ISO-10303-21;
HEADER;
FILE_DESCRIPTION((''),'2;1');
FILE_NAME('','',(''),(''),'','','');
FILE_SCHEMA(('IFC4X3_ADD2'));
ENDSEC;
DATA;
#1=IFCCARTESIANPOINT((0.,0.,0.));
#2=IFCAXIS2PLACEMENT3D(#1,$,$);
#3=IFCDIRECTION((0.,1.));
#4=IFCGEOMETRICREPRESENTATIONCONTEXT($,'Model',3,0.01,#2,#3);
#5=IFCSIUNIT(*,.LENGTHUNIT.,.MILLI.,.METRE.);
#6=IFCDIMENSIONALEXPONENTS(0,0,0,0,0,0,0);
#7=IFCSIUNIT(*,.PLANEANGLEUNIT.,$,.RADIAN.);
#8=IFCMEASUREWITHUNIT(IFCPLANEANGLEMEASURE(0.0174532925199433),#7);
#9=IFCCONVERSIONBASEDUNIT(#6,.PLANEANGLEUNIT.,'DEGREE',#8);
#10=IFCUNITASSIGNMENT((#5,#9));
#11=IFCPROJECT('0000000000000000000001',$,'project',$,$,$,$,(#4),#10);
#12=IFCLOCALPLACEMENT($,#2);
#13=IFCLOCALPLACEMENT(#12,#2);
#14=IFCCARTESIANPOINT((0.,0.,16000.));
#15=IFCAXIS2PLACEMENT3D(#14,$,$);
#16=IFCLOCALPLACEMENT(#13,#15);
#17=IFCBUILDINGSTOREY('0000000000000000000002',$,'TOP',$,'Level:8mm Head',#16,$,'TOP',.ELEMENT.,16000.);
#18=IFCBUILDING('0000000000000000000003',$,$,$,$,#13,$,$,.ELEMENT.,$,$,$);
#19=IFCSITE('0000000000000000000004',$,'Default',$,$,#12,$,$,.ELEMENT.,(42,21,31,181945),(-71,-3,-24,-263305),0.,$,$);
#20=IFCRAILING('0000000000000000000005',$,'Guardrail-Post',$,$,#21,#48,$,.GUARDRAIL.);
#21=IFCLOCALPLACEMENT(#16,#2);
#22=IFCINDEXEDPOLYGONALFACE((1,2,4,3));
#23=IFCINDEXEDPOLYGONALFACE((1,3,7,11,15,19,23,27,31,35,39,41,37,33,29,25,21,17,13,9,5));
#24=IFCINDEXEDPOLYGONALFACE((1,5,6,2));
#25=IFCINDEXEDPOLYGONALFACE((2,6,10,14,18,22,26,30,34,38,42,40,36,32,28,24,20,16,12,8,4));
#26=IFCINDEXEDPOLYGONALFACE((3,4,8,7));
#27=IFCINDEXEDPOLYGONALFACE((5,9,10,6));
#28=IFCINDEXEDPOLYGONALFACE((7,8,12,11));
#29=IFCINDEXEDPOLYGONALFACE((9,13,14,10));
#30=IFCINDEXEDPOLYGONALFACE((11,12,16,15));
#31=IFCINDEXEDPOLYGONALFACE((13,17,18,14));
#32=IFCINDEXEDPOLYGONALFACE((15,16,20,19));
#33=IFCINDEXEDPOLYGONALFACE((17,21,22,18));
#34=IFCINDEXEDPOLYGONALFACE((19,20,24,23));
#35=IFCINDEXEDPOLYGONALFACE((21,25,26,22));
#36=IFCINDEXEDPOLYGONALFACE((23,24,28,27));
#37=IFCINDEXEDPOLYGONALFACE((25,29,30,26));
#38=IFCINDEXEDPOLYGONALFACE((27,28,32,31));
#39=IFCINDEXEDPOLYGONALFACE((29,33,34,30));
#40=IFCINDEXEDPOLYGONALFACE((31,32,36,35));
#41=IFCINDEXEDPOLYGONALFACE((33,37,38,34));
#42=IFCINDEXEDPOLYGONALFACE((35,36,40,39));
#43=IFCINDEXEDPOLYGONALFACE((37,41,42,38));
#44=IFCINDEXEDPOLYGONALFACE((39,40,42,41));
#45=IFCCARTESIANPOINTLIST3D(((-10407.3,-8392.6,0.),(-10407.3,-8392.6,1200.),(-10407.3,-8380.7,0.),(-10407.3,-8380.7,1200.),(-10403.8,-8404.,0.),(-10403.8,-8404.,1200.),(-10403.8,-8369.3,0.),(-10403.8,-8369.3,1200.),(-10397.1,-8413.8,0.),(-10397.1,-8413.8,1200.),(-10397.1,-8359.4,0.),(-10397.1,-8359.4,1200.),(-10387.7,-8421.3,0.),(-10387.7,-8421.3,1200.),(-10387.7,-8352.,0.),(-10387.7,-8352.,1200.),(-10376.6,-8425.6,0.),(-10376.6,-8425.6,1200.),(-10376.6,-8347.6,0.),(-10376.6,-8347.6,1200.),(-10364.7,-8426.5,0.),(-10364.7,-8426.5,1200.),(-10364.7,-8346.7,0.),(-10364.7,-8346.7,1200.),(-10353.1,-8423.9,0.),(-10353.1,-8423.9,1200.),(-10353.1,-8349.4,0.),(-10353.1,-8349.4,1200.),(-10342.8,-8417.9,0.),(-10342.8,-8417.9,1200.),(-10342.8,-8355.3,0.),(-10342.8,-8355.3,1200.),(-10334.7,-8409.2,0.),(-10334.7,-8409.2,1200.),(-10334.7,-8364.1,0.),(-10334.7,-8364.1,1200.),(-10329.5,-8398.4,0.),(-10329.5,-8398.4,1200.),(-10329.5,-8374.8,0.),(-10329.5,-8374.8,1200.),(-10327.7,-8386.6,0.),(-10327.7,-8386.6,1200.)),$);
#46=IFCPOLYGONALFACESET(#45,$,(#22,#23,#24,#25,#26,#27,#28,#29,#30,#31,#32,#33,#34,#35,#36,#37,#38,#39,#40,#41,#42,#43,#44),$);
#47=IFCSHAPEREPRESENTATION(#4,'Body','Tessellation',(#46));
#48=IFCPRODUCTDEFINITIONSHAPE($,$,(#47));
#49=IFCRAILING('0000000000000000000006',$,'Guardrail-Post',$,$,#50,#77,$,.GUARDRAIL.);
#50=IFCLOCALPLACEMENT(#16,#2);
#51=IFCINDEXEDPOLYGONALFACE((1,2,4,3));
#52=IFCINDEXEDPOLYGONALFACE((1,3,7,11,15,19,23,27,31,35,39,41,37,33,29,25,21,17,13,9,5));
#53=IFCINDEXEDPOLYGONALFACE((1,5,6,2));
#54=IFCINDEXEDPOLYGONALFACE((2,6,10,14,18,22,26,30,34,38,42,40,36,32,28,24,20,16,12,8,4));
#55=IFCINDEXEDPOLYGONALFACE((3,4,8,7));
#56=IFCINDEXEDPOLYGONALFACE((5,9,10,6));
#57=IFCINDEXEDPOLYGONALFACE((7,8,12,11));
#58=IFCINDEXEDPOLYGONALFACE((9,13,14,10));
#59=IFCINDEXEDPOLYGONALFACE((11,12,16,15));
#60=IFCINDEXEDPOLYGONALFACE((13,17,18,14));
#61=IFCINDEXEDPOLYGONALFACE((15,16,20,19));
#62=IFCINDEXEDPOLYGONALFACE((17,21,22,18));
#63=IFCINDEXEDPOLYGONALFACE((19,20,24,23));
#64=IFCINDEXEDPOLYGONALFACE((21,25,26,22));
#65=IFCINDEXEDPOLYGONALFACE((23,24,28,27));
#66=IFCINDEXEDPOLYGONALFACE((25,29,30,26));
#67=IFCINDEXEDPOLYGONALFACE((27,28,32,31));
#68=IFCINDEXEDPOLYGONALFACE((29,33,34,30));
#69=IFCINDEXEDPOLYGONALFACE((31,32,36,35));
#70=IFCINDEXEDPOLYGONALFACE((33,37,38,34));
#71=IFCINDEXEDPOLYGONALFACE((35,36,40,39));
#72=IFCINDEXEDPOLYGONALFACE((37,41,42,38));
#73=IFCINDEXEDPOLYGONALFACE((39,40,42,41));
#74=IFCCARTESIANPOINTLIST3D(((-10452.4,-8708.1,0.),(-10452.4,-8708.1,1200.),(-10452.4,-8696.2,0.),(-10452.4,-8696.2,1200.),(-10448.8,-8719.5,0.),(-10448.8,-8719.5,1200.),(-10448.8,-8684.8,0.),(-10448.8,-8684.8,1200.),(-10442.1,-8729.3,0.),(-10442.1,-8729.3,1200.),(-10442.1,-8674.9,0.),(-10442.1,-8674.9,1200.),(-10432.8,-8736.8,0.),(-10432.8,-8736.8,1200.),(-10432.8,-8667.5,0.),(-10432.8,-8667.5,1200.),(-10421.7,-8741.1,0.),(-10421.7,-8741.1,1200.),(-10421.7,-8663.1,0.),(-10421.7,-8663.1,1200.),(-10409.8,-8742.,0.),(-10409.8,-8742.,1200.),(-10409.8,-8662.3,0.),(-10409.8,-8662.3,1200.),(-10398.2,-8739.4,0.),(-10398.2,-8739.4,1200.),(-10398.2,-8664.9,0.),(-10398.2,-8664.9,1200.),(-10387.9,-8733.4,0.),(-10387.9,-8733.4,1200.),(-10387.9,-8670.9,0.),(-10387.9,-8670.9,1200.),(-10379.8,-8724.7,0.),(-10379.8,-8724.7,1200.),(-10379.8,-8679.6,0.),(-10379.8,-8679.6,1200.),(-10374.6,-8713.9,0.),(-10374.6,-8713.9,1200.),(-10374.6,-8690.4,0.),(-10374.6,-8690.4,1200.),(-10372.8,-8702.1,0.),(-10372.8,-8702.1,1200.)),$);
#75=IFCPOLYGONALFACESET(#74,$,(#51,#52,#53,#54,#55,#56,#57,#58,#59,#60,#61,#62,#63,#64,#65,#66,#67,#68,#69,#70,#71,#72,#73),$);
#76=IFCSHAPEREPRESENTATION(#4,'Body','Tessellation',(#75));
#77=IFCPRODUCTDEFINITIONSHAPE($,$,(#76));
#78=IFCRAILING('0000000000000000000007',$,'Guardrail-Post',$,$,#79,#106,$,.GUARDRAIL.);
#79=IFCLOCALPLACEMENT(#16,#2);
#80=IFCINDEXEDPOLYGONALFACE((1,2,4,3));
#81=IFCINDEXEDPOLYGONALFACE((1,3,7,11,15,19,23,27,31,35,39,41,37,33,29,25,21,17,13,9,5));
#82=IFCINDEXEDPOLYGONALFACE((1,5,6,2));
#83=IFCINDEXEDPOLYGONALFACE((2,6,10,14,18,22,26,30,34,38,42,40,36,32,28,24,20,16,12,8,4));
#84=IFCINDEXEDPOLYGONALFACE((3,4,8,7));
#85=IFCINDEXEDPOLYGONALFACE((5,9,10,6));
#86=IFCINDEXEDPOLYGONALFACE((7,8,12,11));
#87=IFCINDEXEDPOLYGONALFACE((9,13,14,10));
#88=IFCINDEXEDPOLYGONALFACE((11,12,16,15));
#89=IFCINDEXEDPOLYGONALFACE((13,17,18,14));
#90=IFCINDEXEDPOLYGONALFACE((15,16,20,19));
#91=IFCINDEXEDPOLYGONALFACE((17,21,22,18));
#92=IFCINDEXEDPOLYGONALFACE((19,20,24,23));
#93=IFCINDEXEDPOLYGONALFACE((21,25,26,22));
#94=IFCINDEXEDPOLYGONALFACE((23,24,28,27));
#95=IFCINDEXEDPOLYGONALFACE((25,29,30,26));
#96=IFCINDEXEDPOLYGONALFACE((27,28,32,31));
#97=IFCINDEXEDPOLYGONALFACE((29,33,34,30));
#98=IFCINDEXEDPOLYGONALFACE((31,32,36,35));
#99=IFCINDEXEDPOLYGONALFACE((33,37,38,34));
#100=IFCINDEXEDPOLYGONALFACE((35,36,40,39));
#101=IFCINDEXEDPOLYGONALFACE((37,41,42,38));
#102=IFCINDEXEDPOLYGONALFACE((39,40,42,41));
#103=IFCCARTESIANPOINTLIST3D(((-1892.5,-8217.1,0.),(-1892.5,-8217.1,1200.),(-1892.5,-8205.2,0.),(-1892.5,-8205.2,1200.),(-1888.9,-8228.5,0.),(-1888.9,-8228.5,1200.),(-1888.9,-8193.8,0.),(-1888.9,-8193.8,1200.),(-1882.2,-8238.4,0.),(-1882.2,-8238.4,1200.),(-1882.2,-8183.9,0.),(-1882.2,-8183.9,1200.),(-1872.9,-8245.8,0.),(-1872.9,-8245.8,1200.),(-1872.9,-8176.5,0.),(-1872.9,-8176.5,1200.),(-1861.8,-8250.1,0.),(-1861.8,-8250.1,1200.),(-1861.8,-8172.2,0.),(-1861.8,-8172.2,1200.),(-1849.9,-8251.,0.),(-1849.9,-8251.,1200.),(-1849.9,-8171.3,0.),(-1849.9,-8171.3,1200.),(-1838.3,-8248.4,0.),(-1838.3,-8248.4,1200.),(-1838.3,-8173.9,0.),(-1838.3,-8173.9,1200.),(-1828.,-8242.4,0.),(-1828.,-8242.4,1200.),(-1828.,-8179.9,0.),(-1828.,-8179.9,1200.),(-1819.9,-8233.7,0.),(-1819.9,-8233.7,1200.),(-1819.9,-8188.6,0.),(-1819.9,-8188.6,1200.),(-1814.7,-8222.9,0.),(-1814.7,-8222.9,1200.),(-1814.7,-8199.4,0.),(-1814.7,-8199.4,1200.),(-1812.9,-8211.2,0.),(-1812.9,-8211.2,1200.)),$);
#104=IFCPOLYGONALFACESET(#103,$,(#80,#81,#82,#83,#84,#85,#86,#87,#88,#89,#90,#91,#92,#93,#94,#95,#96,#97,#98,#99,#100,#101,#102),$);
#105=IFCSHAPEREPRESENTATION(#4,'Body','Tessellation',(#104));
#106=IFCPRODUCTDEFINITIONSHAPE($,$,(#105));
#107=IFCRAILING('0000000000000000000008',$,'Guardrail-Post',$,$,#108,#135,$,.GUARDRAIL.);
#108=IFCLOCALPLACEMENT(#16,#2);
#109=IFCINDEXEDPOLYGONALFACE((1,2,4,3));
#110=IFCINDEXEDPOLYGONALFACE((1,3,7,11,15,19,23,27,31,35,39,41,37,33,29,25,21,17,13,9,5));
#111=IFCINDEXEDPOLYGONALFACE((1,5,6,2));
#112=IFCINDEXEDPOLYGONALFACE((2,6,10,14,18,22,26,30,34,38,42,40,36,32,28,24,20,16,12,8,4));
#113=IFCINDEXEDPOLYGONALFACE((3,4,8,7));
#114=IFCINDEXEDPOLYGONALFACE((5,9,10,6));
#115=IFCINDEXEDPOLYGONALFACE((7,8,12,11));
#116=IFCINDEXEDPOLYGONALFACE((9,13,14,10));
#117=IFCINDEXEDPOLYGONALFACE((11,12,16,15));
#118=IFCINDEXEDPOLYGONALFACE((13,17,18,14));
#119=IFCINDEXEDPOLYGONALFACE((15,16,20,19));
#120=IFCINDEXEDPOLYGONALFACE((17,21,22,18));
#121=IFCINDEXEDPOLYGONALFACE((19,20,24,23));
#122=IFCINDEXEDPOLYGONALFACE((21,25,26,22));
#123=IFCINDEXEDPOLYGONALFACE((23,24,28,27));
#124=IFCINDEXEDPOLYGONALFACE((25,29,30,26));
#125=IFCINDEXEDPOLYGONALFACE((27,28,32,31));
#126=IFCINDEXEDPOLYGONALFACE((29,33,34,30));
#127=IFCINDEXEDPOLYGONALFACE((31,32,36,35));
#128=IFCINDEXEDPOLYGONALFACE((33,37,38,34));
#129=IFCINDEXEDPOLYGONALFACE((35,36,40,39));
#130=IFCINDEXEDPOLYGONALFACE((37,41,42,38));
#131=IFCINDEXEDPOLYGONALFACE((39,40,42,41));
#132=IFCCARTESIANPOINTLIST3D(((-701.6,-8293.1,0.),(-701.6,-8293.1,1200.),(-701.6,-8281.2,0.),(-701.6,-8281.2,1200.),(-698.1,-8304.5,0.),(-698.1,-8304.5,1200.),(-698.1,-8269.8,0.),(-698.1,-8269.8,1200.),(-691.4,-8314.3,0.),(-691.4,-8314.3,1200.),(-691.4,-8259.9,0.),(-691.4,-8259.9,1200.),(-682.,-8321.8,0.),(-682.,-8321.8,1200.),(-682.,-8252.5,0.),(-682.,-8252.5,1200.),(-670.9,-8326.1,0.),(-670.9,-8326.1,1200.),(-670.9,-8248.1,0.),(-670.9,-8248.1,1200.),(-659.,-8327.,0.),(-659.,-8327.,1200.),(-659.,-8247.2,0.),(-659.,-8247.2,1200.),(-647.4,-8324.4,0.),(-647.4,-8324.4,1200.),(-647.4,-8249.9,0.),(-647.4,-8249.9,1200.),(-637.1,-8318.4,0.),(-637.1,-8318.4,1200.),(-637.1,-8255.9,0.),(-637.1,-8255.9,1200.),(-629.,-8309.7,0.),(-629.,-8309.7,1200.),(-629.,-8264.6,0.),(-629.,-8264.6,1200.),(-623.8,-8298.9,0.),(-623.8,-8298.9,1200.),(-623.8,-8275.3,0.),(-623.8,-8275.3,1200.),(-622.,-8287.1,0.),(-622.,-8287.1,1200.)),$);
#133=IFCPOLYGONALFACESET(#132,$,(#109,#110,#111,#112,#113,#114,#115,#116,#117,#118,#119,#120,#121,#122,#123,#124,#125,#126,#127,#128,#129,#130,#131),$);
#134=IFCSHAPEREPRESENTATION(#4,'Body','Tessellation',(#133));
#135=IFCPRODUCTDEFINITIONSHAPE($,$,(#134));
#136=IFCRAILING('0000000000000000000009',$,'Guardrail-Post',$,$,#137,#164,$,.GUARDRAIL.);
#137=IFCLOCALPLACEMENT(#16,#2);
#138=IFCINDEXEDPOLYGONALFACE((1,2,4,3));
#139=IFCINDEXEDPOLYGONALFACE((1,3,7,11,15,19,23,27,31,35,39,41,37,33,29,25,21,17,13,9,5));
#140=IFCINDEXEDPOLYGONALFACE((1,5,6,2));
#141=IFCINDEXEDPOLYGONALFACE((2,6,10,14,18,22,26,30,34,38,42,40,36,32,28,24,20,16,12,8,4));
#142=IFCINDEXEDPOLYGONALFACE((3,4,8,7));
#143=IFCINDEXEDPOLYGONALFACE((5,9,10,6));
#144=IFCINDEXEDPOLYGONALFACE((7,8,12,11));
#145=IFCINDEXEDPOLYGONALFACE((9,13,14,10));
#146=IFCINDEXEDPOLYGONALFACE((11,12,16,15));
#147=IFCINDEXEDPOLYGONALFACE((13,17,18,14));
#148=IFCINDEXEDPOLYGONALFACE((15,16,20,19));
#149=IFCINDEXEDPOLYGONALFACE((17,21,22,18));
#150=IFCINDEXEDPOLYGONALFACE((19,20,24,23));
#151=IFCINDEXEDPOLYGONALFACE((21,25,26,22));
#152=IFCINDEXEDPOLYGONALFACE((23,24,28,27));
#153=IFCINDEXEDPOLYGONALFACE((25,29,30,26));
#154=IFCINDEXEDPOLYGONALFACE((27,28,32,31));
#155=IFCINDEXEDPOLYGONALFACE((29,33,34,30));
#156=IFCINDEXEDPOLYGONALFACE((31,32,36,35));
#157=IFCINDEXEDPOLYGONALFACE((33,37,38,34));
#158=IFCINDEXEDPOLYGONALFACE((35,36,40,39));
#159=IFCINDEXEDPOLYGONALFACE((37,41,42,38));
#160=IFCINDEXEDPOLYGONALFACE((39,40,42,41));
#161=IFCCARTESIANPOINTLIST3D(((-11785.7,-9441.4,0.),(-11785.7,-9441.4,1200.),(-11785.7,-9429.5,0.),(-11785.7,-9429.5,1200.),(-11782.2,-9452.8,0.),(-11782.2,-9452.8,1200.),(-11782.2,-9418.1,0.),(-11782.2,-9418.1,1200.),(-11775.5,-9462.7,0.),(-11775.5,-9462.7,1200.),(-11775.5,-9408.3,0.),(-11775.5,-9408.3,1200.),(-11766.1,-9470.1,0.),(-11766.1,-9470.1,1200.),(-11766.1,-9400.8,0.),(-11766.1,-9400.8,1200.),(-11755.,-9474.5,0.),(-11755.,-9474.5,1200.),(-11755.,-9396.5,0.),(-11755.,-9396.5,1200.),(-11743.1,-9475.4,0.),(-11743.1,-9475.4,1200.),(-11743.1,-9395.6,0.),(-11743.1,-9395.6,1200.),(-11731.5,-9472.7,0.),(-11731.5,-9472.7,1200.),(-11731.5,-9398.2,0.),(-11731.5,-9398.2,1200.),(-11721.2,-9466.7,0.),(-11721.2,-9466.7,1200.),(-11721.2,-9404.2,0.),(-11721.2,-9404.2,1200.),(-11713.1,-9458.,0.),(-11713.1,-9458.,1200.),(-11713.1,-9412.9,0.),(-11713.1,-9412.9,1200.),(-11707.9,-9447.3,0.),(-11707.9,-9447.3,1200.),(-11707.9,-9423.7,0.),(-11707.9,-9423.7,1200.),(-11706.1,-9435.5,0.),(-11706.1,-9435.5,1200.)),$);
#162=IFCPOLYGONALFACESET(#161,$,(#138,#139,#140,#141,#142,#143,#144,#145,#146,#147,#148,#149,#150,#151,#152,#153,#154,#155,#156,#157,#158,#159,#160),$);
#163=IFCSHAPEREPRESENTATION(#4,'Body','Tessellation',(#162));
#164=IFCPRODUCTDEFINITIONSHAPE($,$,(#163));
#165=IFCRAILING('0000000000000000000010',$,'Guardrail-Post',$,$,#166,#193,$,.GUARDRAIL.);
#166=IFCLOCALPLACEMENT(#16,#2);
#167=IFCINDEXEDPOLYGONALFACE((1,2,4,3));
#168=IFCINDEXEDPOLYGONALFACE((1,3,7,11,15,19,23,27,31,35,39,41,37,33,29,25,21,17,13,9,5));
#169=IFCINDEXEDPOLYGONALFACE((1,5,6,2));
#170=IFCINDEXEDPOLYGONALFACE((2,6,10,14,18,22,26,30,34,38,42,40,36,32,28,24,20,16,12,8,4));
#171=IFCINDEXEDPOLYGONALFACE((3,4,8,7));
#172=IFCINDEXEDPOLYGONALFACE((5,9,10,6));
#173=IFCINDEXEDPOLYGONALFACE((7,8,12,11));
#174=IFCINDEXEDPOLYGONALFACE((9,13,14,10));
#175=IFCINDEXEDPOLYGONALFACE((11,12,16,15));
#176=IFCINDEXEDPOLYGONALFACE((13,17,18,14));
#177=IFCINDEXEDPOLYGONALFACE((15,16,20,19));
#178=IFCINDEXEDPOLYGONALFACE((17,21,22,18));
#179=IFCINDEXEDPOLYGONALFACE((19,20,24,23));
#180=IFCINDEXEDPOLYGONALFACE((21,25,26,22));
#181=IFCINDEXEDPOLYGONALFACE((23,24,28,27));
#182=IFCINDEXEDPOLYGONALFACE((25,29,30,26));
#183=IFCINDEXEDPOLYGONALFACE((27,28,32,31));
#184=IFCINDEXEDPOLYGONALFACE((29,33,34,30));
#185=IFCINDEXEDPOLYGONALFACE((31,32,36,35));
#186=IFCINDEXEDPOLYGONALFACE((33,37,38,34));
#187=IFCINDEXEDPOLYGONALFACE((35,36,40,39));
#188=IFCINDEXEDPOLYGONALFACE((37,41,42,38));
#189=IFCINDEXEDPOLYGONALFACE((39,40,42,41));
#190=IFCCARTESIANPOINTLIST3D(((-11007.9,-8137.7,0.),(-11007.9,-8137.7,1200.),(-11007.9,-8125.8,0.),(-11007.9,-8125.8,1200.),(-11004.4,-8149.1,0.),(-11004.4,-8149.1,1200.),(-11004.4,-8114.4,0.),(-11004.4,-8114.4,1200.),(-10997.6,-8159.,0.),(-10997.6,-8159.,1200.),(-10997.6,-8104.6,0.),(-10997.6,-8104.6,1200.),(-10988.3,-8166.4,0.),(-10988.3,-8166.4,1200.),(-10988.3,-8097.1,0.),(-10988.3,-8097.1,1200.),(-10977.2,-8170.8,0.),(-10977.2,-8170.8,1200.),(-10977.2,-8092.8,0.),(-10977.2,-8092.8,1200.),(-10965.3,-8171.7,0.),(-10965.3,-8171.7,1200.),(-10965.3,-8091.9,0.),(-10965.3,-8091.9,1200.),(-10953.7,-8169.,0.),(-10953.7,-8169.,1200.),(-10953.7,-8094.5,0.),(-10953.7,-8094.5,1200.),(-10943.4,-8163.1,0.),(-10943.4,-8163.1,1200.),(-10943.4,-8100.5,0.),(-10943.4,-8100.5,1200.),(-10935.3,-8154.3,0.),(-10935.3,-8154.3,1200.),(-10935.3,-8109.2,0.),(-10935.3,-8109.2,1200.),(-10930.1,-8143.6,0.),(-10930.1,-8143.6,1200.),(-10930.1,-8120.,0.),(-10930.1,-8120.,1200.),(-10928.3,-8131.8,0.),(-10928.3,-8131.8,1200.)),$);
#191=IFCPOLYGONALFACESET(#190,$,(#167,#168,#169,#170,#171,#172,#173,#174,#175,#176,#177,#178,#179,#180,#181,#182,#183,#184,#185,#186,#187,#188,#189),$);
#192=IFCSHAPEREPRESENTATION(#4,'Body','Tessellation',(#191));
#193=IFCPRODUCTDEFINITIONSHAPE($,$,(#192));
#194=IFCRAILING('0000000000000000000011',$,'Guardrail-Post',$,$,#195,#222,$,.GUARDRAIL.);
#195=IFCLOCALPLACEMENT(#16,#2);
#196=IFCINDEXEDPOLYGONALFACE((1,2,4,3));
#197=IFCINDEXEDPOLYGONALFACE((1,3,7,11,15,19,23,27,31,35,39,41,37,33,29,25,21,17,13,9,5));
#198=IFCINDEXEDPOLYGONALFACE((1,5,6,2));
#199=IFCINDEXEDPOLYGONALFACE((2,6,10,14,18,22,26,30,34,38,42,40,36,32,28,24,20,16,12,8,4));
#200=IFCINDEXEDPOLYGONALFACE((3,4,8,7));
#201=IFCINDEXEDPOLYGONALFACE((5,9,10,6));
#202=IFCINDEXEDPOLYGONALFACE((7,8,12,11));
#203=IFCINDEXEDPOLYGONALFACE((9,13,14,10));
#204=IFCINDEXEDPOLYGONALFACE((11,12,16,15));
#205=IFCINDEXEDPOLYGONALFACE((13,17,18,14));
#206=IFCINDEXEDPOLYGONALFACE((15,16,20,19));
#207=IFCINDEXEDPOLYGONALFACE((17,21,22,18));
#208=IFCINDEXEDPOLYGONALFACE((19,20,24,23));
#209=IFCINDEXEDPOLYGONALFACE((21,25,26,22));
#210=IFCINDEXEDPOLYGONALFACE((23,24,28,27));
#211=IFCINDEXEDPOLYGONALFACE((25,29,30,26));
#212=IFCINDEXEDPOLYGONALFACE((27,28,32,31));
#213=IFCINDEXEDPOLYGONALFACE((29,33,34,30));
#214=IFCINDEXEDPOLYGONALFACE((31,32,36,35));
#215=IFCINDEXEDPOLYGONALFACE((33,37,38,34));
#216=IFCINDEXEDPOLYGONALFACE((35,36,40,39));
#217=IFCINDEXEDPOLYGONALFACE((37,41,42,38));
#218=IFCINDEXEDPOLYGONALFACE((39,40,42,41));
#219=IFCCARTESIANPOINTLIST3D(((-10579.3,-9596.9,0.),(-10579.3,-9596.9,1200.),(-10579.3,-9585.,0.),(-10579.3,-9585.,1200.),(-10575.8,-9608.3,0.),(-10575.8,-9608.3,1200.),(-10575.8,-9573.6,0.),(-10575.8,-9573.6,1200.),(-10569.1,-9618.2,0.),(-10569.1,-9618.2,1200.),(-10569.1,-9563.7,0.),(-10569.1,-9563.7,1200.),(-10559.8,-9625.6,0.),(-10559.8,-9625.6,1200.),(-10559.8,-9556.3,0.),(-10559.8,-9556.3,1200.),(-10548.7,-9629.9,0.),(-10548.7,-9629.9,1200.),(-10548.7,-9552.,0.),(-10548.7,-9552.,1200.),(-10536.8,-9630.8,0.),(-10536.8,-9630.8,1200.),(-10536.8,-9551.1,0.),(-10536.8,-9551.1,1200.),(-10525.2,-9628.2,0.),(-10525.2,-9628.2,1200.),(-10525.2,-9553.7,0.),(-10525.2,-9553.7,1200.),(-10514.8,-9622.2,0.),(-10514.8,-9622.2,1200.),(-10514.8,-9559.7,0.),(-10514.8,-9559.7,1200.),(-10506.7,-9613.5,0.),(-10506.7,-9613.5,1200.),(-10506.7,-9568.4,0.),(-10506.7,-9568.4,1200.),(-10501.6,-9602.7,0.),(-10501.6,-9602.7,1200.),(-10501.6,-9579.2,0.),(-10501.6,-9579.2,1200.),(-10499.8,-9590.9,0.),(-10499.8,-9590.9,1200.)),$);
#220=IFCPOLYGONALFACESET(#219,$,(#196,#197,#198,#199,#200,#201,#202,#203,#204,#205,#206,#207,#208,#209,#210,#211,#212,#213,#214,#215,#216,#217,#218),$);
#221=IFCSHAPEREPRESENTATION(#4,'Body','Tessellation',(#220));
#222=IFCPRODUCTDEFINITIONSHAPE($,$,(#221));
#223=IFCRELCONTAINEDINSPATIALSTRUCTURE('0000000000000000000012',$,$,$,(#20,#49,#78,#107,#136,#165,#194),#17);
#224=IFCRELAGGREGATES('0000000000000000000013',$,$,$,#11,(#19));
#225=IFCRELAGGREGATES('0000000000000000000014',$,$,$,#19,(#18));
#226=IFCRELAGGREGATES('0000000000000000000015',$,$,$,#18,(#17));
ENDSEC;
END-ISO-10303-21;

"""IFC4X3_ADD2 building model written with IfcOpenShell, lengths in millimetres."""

from ifc_helpers import new_model, entity, si_unit, converted_unit, direction, frame, origin, origin_with_axes, origin_2d, place, context, project, spatial, circle, extrude, element, save


model = new_model("IFC4X3_ADD2")

# Units and contexts
model_context = context("Model", 3, precision=0.01, world=origin(), true_north=direction((0.0, 1.0)))
ifc_project = project(units=[si_unit("LENGTHUNIT", "METRE", prefix="MILLI"), converted_unit("PLANEANGLEUNIT", "DEGREE", entity("IfcPlaneAngleMeasure", 0.0174532925199433), si_unit("PLANEANGLEUNIT", "RADIAN"), dimensions=[0, 0, 0, 0, 0, 0, 0])], contexts=[model_context])

# Site, building, storey
site_placement = place(None, origin())
site = spatial("IfcSite", under=ifc_project, at=site_placement, Name="Default", CompositionType="ELEMENT", RefLatitude=(42, 21, 31, 181945), RefLongitude=(-71, -3, -24, -263305), RefElevation=0.0)
building_placement = place(site_placement, origin())
building = spatial("IfcBuilding", under=site, at=building_placement, CompositionType="ELEMENT")
storey_placement = place(building_placement, frame((0.0, 0.0, 16000.0)))
storey = spatial("IfcBuildingStorey", under=building, at=storey_placement, Name="TOP", ObjectType="Level:8mm Head", LongName="TOP", CompositionType="ELEMENT", Elevation=16000.0)

# Railings
for number, where, z_axis, x_axis, name in (
    (1, (-10367.7, -8386.6, 16000.0), (0.0, 0.0, 1.0), (1.0, 0.0, 0.0), "Guardrail-Post"),
    (2, (-10412.8, -8702.1, 16000.0), (0.0, 0.0, 1.0), (1.0, 0.0, 0.0), "Guardrail-Post"),
    (3, (-1852.9, -8211.2, 16000.0), (0.0, 0.0, 1.0), (1.0, 0.0, 0.0), "Guardrail-Post"),
    (4, (-662.0, -8287.1, 16000.0), (0.0, 0.0, 1.0), (1.0, 0.0, 0.0), "Guardrail-Post"),
    (5, (-11746.1, -9435.5, 16000.0), (0.0, 0.0, 1.0), (1.0, 0.0, 0.0), "Guardrail-Post"),
    (6, (-10968.3, -8131.8, 16000.0), (0.0, 0.0, 1.0), (1.0, 0.0, 0.0), "Guardrail-Post"),
    (7, (-10539.8, -9590.9, 16000.0), (0.0, 0.0, 1.0), (1.0, 0.0, 0.0), "Guardrail-Post"),
):
    element("IfcRailing", number, at=place(None, frame(where, z_axis=z_axis, x_axis=x_axis)), inside=storey, Name=name, PredefinedType="GUARDRAIL", context=model_context, shape_type="SweptSolid", body=[
        extrude(circle(Radius=40.0, at=origin_2d()), origin_with_axes(), (0.0, 0.0, 1.0), 1200.0),
    ])

save(model, "model.ifc")
